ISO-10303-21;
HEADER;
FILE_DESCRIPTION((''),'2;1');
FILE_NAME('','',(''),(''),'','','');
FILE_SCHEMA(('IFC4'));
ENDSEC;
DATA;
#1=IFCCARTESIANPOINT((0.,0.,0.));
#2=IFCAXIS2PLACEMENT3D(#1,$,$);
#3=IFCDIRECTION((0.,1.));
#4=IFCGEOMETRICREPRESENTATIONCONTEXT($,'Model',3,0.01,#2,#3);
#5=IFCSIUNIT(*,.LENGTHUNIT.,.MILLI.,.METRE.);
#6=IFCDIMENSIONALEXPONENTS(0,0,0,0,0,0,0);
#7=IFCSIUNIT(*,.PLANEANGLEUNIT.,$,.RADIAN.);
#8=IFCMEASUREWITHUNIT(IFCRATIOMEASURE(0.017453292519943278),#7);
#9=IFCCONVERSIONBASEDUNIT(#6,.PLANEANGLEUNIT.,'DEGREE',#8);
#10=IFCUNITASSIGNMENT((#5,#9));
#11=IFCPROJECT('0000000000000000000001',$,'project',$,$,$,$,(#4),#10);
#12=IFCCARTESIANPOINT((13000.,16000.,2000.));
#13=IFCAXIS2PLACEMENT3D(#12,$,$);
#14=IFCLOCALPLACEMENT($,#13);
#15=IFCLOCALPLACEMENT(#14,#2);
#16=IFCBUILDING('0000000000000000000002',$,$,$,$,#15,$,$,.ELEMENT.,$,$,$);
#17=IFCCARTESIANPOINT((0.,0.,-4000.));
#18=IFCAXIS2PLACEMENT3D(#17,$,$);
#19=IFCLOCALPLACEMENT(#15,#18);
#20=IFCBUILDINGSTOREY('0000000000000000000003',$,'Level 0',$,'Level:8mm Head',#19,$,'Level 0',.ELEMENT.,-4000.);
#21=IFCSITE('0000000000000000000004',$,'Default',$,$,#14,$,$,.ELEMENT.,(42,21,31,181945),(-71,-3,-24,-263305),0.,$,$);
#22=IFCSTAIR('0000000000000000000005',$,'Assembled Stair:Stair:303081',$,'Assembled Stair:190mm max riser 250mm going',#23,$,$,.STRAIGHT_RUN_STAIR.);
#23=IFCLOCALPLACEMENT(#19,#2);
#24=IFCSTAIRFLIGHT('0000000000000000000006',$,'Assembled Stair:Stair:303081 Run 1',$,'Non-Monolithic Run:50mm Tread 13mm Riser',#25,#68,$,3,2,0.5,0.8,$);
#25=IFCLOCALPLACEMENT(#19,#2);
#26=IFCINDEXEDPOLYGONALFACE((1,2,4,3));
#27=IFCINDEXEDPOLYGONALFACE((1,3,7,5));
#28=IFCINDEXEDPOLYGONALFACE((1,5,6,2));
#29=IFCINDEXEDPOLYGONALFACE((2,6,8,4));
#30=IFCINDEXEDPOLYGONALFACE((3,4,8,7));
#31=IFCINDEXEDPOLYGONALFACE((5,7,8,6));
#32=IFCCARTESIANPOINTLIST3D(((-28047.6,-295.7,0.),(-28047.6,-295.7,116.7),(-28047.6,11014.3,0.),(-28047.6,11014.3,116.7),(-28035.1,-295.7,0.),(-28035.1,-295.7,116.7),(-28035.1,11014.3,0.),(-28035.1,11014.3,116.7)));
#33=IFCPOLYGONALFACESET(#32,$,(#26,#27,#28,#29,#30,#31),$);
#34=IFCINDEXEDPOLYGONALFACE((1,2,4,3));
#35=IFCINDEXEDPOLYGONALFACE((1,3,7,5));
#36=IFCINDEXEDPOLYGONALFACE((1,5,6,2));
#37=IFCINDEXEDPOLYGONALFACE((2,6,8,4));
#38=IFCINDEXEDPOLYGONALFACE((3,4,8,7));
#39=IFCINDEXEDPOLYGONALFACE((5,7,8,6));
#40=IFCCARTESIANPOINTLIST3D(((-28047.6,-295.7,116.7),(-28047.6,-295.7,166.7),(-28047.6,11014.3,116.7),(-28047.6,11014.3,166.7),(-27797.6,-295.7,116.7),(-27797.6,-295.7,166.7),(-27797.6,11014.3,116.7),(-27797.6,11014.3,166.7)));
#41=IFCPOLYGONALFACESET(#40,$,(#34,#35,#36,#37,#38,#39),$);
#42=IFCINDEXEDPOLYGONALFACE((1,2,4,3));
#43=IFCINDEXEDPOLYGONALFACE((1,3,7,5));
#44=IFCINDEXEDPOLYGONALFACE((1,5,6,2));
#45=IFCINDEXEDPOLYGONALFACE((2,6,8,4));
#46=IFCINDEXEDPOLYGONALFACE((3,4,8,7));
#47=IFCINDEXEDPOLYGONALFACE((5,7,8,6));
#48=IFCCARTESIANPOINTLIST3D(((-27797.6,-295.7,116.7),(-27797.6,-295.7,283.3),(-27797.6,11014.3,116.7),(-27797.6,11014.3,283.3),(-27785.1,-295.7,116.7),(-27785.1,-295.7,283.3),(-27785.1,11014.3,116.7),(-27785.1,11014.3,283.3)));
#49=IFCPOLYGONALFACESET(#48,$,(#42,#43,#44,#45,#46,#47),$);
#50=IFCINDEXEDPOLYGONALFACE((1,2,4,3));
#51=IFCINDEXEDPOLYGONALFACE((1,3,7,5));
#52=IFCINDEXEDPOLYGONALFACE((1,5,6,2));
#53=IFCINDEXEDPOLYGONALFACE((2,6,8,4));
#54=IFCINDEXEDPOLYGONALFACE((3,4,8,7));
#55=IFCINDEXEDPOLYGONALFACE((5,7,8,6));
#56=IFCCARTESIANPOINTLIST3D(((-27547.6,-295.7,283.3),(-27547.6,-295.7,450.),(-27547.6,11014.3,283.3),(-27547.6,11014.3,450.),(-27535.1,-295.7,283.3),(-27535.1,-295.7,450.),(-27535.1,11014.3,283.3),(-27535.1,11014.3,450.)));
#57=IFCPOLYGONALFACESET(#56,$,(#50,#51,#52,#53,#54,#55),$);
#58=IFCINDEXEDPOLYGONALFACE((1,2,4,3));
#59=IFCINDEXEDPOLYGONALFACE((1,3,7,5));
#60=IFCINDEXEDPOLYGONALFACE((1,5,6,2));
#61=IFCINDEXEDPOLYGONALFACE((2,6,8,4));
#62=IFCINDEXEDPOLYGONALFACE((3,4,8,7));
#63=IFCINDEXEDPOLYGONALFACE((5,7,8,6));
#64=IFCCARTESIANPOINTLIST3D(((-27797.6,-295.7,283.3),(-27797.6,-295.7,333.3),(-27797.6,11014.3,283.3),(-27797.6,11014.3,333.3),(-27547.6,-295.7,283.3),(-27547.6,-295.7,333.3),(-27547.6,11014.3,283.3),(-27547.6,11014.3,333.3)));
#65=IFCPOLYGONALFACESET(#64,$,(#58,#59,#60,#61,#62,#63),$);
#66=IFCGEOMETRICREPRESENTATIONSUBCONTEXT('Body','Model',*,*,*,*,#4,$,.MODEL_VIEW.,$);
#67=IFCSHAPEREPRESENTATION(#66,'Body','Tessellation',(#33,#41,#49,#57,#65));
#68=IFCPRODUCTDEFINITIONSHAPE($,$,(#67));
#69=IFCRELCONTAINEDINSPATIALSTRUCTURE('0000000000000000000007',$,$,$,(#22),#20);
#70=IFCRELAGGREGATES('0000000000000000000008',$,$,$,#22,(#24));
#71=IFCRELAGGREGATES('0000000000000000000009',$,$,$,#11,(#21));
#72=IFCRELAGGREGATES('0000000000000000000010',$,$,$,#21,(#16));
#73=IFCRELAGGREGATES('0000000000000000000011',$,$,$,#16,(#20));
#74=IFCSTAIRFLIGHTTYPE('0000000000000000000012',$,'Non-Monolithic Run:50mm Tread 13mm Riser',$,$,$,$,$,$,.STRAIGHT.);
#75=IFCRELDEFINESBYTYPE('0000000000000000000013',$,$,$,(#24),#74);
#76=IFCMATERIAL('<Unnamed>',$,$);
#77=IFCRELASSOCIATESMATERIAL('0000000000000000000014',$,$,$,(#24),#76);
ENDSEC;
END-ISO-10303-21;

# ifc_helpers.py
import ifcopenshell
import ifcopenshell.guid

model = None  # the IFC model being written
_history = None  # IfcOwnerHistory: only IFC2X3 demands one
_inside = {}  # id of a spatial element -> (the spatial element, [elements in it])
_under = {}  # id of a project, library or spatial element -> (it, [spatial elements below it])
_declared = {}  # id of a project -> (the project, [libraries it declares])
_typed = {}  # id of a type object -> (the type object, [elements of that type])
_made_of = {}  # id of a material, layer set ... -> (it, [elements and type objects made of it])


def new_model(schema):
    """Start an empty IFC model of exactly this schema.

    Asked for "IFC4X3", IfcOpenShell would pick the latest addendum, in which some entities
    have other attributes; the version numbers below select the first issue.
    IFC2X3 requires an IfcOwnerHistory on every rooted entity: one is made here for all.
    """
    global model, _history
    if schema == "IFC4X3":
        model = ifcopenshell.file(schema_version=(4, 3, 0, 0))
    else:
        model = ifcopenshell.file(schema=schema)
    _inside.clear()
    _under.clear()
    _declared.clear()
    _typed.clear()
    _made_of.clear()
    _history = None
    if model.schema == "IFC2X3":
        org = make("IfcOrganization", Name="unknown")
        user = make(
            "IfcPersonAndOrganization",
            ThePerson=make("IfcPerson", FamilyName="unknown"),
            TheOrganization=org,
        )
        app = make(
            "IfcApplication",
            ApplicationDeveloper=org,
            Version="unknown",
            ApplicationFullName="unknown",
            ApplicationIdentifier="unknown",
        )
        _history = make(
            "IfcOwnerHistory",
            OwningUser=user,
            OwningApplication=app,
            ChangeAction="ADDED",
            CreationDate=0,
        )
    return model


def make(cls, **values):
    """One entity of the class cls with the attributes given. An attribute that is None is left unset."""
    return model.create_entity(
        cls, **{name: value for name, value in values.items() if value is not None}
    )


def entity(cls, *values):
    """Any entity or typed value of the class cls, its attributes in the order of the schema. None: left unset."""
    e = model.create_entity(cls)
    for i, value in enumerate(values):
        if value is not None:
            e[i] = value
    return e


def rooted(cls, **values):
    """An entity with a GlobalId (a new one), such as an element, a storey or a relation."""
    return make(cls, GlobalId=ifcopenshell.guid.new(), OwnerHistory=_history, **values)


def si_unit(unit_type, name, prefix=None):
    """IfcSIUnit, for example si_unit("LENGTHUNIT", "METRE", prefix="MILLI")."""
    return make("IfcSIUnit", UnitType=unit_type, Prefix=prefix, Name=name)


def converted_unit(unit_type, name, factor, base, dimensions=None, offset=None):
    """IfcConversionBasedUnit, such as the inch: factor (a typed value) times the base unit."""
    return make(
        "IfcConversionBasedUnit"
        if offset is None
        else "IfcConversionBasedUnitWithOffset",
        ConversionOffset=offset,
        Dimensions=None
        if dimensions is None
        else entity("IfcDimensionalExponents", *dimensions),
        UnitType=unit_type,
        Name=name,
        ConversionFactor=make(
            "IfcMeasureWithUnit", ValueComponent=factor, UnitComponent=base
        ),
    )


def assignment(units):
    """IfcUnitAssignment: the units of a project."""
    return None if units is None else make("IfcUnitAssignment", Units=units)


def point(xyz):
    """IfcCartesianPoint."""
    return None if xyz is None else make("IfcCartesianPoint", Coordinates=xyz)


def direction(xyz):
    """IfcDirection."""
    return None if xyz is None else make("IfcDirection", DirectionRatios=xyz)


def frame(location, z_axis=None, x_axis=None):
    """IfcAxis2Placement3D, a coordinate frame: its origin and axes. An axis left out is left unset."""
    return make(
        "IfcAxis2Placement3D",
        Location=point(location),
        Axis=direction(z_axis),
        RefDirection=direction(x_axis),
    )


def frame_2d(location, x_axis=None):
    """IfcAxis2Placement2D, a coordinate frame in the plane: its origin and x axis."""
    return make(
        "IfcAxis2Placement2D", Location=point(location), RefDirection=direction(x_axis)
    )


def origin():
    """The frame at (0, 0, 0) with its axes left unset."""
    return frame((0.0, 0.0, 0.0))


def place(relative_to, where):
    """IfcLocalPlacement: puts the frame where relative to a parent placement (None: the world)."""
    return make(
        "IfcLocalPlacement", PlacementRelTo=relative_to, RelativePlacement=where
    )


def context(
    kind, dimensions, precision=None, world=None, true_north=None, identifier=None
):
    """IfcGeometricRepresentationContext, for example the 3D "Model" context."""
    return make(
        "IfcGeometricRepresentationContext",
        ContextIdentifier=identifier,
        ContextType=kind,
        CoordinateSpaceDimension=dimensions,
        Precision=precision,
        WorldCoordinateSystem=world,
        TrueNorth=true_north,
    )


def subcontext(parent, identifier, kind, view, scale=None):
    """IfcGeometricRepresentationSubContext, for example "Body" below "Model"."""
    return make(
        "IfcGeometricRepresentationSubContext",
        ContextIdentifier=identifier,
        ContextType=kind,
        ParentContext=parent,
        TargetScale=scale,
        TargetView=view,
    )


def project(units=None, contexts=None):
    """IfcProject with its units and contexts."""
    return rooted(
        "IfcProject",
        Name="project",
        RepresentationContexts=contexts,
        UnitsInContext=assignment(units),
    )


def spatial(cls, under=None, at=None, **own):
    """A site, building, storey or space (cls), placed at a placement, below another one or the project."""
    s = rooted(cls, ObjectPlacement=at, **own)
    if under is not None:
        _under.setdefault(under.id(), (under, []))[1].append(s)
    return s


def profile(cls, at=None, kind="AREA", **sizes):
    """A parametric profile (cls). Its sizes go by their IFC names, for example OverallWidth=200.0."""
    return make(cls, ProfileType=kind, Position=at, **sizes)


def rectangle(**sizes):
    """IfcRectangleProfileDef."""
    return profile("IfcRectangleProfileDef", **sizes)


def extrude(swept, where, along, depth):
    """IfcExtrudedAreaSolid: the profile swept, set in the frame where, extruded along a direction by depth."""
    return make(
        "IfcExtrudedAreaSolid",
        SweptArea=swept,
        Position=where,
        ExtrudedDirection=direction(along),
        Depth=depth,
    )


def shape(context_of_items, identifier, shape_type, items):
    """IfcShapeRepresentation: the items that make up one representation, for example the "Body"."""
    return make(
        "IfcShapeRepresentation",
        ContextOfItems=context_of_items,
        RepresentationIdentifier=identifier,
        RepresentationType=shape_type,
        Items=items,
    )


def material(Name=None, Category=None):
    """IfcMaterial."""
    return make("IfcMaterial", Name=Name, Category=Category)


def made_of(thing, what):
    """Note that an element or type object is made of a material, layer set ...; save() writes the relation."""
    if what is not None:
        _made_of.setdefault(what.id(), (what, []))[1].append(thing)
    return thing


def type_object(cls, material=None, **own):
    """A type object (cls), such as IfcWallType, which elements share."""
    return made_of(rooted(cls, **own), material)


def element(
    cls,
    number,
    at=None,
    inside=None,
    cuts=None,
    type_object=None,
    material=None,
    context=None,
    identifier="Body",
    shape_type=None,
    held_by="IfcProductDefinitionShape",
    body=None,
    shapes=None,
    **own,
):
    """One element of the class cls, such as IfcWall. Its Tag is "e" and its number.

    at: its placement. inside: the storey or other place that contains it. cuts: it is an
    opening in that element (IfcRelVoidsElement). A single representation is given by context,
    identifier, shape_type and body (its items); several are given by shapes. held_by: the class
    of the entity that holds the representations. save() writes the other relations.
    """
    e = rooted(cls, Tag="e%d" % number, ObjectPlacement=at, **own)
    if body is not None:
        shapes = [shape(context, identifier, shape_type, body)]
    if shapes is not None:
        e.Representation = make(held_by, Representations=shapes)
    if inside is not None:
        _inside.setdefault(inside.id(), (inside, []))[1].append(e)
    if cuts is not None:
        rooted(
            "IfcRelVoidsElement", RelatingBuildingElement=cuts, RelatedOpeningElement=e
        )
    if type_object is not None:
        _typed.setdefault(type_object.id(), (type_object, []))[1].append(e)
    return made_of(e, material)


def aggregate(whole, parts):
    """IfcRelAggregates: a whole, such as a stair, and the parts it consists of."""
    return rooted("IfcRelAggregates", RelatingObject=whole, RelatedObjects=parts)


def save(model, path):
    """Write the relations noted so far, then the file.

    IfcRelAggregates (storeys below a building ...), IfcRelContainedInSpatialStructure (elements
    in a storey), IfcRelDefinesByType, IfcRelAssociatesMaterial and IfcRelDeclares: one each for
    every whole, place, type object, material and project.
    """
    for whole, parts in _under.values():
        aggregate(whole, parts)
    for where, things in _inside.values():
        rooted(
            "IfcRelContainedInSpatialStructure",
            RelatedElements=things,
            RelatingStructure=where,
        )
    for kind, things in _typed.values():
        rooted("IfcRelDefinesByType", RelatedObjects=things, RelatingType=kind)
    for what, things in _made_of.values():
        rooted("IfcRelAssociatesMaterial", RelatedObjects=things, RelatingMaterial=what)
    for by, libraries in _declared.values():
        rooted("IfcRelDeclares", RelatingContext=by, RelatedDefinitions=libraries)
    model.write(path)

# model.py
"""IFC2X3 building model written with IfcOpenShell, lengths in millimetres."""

from ifc_helpers import new_model, entity, si_unit, converted_unit, direction, frame, frame_2d, origin, place, context, subcontext, project, spatial, rectangle, extrude, material, type_object, element, aggregate, save


model = new_model("IFC2X3")

# Units and contexts
model_context = context("Model", 3, precision=0.01, world=origin(), true_north=direction((0.0, 1.0)))
body_context = subcontext(model_context, "Body", "Model", "MODEL_VIEW")
ifc_project = project(units=[si_unit("LENGTHUNIT", "METRE", prefix="MILLI"), converted_unit("PLANEANGLEUNIT", "DEGREE", entity("IfcRatioMeasure", 0.017453292519943278), si_unit("PLANEANGLEUNIT", "RADIAN"), dimensions=[0, 0, 0, 0, 0, 0, 0])], contexts=[model_context])

# Site, building, storey
site_placement = place(None, frame((13000.0, 16000.0, 2000.0)))
site = spatial("IfcSite", under=ifc_project, at=site_placement, Name="Default", CompositionType="ELEMENT", RefLatitude=(42, 21, 31, 181945), RefLongitude=(-71, -3, -24, -263305), RefElevation=0.0)
building_placement = place(site_placement, origin())
building = spatial("IfcBuilding", under=site, at=building_placement, CompositionType="ELEMENT")
storey_placement = place(building_placement, frame((0.0, 0.0, -4000.0)))
storey = spatial("IfcBuildingStorey", under=building, at=storey_placement, Name="Level 0", ObjectType="Level:8mm Head", LongName="Level 0", CompositionType="ELEMENT", Elevation=-4000.0)

# Stair
stair_placement = place(storey_placement, origin())
stair = element("IfcStair", 1, at=stair_placement, inside=storey, Name="Assembled Stair:Stair:303081", ObjectType="Assembled Stair:190mm max riser 250mm going", ShapeType="STRAIGHT_RUN_STAIR")
ifc_material_1 = material(Name="<Unnamed>")

# Stair flight
stair_flight_type = type_object("IfcStairFlightType", Name="Non-Monolithic Run:50mm Tread 13mm Riser", PredefinedType="STRAIGHT")
stair_flight_placement = place(stair_placement, origin())
stair_flight = element("IfcStairFlight", 2, at=stair_flight_placement, type_object=stair_flight_type, material=ifc_material_1, Name="Assembled Stair:Stair:303081 Run 1", ObjectType="Non-Monolithic Run:50mm Tread 13mm Riser", NumberOfRiser=3, NumberOfTreads=2, RiserHeight=0.5, TreadLength=0.8, context=body_context, shape_type="SweptSolid", body=[
    extrude(rectangle(XDim=11310.0, YDim=12.5, at=frame_2d((0.0, 0.0), x_axis=(1.0, 0.0))), frame((-28041.4, 5359.3, 0.0), z_axis=(0.0, 0.0, 1.0), x_axis=(0.0, 1.0, 0.0)), (0.0, 0.0, 1.0), 116.7),
    extrude(rectangle(XDim=250.0, YDim=11310.0, at=frame_2d((0.0, 0.0), x_axis=(1.0, 0.0))), frame((-27922.6, 5359.3, 116.7), z_axis=(0.0, 0.0, 1.0), x_axis=(-1.0, 0.0, 0.0)), (0.0, 0.0, 1.0), 50.0),
    extrude(rectangle(XDim=11310.0, YDim=12.5, at=frame_2d((0.0, 0.0), x_axis=(1.0, 0.0))), frame((-27791.4, 5359.3, 116.7), z_axis=(0.0, 0.0, 1.0), x_axis=(0.0, 1.0, 0.0)), (0.0, 0.0, 1.0), 166.7),
    extrude(rectangle(XDim=11310.0, YDim=12.5, at=frame_2d((0.0, 0.0), x_axis=(1.0, 0.0))), frame((-27541.4, 5359.3, 283.3), z_axis=(0.0, 0.0, 1.0), x_axis=(0.0, 1.0, 0.0)), (0.0, 0.0, 1.0), 166.7),
    extrude(rectangle(XDim=250.0, YDim=11310.0, at=frame_2d((0.0, 0.0), x_axis=(1.0, 0.0))), frame((-27672.6, 5359.3, 283.3), z_axis=(0.0, 0.0, 1.0), x_axis=(-1.0, 0.0, 0.0)), (0.0, 0.0, 1.0), 50.0),
])
aggregate(stair, [stair_flight])

save(model, "model.ifc")
